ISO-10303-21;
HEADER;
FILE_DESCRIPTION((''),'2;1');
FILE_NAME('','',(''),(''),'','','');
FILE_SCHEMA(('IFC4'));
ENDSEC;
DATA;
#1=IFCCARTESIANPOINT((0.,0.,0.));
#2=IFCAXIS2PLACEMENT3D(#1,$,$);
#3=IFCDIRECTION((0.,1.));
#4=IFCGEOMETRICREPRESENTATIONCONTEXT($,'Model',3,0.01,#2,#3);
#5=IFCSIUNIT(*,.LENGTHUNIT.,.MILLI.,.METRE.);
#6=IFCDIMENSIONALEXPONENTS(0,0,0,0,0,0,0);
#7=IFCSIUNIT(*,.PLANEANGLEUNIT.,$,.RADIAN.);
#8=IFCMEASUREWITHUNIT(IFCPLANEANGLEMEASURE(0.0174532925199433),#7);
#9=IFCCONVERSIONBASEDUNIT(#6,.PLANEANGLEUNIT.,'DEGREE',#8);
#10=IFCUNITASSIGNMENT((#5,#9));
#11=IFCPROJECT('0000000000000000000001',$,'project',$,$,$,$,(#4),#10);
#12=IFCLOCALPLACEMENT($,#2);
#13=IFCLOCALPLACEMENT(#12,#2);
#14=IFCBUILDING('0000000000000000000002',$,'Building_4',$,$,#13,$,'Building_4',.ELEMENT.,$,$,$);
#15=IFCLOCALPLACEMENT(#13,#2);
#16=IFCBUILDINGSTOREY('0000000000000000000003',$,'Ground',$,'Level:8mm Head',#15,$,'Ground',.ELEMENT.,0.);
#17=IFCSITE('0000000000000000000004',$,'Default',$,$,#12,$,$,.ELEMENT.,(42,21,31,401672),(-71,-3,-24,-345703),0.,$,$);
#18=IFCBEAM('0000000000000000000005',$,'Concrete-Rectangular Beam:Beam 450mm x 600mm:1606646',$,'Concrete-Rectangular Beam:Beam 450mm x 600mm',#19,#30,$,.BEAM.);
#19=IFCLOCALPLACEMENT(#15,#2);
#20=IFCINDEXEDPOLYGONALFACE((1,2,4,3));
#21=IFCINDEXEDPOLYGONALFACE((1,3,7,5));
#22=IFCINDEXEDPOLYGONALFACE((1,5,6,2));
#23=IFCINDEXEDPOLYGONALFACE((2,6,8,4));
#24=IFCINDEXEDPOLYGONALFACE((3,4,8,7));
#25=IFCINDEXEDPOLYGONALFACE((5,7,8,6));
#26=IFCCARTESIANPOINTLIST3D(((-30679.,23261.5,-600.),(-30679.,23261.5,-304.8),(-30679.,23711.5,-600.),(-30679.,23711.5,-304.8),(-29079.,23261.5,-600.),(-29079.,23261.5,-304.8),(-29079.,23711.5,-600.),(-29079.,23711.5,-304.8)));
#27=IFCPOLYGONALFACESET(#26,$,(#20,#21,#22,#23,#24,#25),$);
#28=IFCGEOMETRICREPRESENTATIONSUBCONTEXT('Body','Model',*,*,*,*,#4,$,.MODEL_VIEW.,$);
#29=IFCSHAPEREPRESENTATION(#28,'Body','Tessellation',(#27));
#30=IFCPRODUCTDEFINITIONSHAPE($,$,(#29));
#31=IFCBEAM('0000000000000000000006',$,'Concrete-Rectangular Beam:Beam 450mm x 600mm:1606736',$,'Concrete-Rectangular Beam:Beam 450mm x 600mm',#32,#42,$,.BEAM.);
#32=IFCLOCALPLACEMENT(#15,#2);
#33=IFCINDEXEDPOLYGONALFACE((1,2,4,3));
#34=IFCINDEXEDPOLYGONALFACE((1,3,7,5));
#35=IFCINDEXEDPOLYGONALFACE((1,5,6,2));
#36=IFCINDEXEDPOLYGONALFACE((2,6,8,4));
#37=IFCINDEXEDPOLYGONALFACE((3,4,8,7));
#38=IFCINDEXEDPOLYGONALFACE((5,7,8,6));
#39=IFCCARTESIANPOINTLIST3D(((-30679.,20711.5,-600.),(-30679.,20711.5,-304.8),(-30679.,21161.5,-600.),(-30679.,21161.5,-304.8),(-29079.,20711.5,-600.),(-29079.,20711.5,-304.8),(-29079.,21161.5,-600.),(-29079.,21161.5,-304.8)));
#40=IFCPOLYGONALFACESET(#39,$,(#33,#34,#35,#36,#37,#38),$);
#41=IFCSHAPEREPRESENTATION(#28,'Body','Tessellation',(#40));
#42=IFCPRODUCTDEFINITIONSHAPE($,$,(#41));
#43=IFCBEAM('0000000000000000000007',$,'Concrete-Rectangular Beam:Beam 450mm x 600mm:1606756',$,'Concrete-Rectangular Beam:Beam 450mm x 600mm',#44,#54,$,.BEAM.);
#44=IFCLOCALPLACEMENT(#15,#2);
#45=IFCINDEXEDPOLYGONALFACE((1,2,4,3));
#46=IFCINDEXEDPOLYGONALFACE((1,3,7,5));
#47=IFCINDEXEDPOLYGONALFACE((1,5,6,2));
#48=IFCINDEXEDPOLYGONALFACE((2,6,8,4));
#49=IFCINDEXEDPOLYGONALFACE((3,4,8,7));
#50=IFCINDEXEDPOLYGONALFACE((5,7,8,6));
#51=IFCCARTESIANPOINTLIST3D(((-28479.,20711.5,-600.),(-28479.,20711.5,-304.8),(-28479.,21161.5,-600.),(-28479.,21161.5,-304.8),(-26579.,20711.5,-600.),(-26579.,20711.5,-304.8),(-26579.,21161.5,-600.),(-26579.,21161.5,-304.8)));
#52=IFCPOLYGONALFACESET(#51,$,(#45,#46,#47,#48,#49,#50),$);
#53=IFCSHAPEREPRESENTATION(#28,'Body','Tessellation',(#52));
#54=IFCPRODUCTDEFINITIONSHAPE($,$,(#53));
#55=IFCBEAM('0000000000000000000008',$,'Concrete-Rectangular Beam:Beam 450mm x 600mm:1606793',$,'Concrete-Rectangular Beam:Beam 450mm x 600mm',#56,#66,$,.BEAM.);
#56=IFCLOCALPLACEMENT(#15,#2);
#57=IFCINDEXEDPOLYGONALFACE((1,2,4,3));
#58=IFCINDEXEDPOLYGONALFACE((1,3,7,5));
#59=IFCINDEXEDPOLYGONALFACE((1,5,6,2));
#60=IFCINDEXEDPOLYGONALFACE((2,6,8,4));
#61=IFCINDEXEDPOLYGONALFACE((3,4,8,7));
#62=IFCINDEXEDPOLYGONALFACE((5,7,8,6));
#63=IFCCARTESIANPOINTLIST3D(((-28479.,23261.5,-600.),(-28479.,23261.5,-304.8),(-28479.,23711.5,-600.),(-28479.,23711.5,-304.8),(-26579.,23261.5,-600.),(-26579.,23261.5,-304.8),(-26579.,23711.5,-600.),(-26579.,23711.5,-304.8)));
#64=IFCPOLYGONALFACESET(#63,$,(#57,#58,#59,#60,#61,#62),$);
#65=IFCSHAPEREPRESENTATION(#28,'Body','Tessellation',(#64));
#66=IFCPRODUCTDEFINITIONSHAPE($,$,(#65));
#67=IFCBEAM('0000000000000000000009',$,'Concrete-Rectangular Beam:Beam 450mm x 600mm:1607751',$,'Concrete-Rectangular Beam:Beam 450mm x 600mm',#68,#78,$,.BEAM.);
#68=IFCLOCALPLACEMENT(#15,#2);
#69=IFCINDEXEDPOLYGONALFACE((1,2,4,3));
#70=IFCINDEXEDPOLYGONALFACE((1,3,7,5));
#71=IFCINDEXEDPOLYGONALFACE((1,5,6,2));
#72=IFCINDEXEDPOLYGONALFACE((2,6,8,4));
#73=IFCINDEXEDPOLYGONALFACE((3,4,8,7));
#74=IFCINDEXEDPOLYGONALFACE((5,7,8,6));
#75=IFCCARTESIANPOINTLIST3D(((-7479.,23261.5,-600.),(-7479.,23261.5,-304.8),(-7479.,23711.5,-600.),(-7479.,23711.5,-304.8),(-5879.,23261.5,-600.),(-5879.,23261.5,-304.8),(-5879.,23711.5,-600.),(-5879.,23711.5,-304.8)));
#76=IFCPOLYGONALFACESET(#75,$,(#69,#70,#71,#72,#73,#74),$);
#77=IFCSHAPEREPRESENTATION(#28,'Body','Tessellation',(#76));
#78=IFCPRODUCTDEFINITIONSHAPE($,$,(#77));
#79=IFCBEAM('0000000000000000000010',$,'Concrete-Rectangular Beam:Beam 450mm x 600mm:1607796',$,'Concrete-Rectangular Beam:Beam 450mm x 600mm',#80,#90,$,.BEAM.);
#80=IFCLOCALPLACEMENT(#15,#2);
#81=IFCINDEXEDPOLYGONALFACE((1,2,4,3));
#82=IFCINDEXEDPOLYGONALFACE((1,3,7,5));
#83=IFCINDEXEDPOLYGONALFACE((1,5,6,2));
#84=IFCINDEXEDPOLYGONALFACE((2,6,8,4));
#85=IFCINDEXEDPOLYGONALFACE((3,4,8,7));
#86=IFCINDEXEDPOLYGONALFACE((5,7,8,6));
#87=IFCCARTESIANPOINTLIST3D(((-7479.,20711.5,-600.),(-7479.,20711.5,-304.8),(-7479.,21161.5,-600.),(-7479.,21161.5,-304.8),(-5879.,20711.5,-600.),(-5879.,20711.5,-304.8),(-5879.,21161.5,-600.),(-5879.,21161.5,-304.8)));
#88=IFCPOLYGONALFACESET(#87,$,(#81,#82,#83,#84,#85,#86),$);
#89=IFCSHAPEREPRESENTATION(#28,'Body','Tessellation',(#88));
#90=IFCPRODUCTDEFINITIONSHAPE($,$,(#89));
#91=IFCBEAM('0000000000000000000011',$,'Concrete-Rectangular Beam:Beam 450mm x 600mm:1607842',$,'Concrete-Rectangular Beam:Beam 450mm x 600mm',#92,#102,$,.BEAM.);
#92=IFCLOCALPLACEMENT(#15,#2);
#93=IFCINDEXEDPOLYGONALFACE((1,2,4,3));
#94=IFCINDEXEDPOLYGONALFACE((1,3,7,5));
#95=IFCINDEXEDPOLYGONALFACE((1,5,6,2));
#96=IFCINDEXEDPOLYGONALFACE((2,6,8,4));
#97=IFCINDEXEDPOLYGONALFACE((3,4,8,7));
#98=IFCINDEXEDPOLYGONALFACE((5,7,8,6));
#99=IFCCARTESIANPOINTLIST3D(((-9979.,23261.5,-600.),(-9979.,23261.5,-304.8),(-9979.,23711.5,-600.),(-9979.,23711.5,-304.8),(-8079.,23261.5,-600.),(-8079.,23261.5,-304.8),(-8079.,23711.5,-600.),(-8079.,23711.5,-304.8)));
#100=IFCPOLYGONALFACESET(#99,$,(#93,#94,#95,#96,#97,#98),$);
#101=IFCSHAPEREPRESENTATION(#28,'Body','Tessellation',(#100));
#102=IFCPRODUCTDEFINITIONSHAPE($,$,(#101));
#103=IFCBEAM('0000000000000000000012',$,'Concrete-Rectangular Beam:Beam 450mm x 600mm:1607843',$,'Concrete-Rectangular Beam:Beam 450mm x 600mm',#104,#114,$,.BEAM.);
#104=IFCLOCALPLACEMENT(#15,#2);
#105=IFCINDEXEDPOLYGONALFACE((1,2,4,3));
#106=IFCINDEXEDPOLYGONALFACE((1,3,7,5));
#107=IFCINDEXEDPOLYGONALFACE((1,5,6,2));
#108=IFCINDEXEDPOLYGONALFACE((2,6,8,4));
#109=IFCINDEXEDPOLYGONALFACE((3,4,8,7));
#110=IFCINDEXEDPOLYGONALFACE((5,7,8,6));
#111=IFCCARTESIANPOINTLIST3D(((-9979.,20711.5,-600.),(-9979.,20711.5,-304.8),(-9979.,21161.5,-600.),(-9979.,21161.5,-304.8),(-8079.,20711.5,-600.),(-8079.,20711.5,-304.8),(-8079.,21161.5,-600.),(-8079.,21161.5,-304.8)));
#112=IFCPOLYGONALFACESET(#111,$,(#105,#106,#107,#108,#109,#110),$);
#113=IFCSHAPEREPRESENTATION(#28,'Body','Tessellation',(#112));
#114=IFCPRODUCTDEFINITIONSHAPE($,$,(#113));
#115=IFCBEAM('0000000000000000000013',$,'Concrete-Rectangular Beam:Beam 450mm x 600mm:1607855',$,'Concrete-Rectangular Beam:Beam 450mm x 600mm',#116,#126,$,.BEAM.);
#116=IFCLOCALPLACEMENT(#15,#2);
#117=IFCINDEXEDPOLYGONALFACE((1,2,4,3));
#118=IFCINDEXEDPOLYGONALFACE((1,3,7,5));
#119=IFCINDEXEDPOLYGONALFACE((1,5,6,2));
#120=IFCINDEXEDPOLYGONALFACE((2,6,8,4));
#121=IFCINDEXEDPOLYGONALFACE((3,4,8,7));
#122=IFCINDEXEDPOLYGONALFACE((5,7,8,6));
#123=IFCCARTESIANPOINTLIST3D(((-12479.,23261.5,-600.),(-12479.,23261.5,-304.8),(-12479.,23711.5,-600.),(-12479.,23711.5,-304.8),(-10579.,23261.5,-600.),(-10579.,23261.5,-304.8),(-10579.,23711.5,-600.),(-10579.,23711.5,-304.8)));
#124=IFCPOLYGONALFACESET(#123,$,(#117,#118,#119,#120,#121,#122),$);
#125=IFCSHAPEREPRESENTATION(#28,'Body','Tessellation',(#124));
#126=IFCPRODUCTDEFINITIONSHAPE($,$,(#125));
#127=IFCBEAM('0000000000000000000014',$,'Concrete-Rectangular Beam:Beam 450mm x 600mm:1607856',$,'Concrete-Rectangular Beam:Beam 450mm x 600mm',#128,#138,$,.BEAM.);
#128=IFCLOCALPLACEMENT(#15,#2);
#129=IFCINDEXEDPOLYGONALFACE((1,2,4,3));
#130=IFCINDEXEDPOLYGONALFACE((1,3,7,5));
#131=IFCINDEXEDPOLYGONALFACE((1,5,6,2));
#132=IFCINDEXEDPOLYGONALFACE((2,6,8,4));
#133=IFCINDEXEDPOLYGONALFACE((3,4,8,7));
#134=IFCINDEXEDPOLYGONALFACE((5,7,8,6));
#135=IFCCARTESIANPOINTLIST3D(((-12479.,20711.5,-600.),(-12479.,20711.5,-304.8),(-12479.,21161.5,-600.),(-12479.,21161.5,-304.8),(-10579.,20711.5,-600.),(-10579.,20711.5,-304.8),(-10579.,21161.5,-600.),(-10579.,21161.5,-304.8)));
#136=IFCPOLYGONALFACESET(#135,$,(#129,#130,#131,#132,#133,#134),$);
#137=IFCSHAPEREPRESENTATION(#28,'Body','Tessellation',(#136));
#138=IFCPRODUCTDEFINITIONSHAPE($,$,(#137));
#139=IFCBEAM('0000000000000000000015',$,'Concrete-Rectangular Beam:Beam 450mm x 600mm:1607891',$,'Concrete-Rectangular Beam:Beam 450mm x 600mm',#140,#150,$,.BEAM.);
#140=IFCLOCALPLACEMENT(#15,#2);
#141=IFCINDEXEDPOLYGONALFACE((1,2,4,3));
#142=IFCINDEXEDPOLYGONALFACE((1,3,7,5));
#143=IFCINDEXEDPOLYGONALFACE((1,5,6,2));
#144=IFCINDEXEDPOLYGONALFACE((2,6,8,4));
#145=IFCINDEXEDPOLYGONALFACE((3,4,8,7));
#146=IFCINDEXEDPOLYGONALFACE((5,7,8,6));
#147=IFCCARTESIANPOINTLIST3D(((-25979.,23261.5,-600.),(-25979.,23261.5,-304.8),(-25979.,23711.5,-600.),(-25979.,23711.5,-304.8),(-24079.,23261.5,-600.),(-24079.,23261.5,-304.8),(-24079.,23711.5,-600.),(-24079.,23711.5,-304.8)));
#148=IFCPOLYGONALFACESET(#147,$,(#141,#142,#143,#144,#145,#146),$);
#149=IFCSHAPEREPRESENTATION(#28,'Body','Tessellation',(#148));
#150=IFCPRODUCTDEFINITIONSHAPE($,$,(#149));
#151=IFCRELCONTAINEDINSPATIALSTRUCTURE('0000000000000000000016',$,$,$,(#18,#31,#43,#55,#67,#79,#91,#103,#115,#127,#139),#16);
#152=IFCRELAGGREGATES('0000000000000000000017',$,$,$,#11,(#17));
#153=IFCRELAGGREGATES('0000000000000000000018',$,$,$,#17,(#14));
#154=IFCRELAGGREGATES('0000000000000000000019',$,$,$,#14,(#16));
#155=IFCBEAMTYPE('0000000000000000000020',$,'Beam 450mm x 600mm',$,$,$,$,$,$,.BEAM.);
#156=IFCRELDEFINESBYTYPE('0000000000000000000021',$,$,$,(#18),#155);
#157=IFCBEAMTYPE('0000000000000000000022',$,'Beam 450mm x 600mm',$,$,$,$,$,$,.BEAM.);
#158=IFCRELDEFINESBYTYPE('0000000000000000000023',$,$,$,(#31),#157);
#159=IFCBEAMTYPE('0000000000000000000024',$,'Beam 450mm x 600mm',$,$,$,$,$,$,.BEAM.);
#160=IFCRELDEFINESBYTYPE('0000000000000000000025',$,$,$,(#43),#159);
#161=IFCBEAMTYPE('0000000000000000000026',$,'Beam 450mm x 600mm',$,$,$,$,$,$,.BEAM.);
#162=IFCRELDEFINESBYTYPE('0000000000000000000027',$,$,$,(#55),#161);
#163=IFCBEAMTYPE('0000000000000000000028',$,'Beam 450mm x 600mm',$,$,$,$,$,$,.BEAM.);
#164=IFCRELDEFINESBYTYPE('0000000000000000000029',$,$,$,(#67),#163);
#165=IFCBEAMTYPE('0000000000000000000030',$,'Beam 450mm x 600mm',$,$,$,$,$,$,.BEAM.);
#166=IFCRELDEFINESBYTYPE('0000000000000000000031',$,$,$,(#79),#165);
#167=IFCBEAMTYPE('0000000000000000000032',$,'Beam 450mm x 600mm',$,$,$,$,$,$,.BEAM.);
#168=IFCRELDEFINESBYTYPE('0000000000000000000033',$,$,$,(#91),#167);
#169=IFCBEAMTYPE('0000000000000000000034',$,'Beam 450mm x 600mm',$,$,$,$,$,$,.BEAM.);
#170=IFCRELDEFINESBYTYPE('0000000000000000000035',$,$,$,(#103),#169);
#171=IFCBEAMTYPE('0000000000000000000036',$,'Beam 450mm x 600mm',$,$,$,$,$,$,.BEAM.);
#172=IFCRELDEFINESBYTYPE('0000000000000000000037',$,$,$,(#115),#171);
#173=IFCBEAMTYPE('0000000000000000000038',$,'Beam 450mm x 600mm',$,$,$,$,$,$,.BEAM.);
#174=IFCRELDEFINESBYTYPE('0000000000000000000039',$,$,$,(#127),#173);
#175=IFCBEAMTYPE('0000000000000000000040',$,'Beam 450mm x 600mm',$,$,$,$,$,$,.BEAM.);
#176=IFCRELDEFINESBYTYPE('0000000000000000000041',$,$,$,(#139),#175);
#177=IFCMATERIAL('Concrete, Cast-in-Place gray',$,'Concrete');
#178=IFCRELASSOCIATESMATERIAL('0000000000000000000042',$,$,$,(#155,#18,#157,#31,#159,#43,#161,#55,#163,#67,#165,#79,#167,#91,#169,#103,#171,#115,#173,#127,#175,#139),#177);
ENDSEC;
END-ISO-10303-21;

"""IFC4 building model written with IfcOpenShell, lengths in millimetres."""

from ifc_helpers import new_model, entity, si_unit, converted_unit, direction, frame, origin, place, context, subcontext, project, spatial, indexed_curve, outline, extrude, source, transform, mapped, material, type_object, type_shapes, element, save


model = new_model("IFC4")

# Units and contexts
model_context = context("Model", 3, precision=0.01, world=origin(), true_north=direction((0.0, 1.0)))
body_context = subcontext(model_context, "Body", "Model", "MODEL_VIEW")
ifc_project = project(units=[si_unit("LENGTHUNIT", "METRE", prefix="MILLI"), converted_unit("PLANEANGLEUNIT", "DEGREE", entity("IfcPlaneAngleMeasure", 0.0174532925199433), si_unit("PLANEANGLEUNIT", "RADIAN"), dimensions=[0, 0, 0, 0, 0, 0, 0])], contexts=[model_context])

# Site, building, storey
site_placement = place(None, origin())
site = spatial("IfcSite", under=ifc_project, at=site_placement, Name="Default", CompositionType="ELEMENT", RefLatitude=(42, 21, 31, 401672), RefLongitude=(-71, -3, -24, -345703), RefElevation=0.0)
building_placement = place(site_placement, origin())
building = spatial("IfcBuilding", under=site, at=building_placement, Name="Building_4", LongName="Building_4", CompositionType="ELEMENT")
storey_placement = place(building_placement, origin())
storey = spatial("IfcBuildingStorey", under=building, at=storey_placement, Name="Ground", ObjectType="Level:8mm Head", LongName="Ground", CompositionType="ELEMENT", Elevation=0.0)

# Shared definitions
ifc_material_1 = material(Name="Concrete, Cast-in-Place gray", Category="Concrete")

# Beams
beam_type_1 = type_object("IfcBeamType", Name="Beam 450mm x 600mm", PredefinedType="BEAM", material=ifc_material_1)
shared_shape_1 = source(origin(), body_context, "Body", "SweptSolid", [
    extrude(outline(indexed_curve([(-147.6, -225.0), (147.6, -225.0), (147.6, 225.0), (-147.6, 225.0), (-147.6, -225.0)], self_intersect=False)), frame((-30679.0, 23486.5, -452.4), z_axis=(1.0, 0.0, 0.0), x_axis=(0.0, 0.0, -1.0)), (0.0, 0.0, 1.0), 1600.0),
])
type_shapes(beam_type_1, [shared_shape_1])
beam_1_placement = place(storey_placement, origin())
element("IfcBeam", 1, at=beam_1_placement, inside=storey, type_object=beam_type_1, material=ifc_material_1, Name="Concrete-Rectangular Beam:Beam 450mm x 600mm:1606646", ObjectType="Concrete-Rectangular Beam:Beam 450mm x 600mm", PredefinedType="BEAM", context=body_context, shape_type="MappedRepresentation", body=[
    mapped(shared_shape_1, transform((0.0, 0.0, 0.0), scale=1.0)),
])
beam_type_2 = type_object("IfcBeamType", Name="Beam 450mm x 600mm", PredefinedType="BEAM", material=ifc_material_1)
shared_shape_2 = source(origin(), body_context, "Body", "SweptSolid", [
    extrude(outline(indexed_curve([(-147.6, -225.0), (147.6, -225.0), (147.6, 225.0), (-147.6, 225.0), (-147.6, -225.0)], self_intersect=False)), frame((-30679.0, 20936.5, -452.4), z_axis=(1.0, 0.0, 0.0), x_axis=(0.0, 0.0, -1.0)), (0.0, 0.0, 1.0), 1600.0),
])
type_shapes(beam_type_2, [shared_shape_2])
beam_2_placement = place(storey_placement, origin())
element("IfcBeam", 2, at=beam_2_placement, inside=storey, type_object=beam_type_2, material=ifc_material_1, Name="Concrete-Rectangular Beam:Beam 450mm x 600mm:1606736", ObjectType="Concrete-Rectangular Beam:Beam 450mm x 600mm", PredefinedType="BEAM", context=body_context, shape_type="MappedRepresentation", body=[
    mapped(shared_shape_2, transform((0.0, 0.0, 0.0), scale=1.0)),
])
beam_type_3 = type_object("IfcBeamType", Name="Beam 450mm x 600mm", PredefinedType="BEAM", material=ifc_material_1)
shared_shape_3 = source(origin(), body_context, "Body", "SweptSolid", [
    extrude(outline(indexed_curve([(-147.6, -225.0), (147.6, -225.0), (147.6, 225.0), (-147.6, 225.0), (-147.6, -225.0)], self_intersect=False)), frame((-28479.0, 20936.5, -452.4), z_axis=(1.0, 0.0, 0.0), x_axis=(0.0, 0.0, -1.0)), (0.0, 0.0, 1.0), 1900.0),
])
type_shapes(beam_type_3, [shared_shape_3])
beam_3_placement = place(storey_placement, origin())
element("IfcBeam", 3, at=beam_3_placement, inside=storey, type_object=beam_type_3, material=ifc_material_1, Name="Concrete-Rectangular Beam:Beam 450mm x 600mm:1606756", ObjectType="Concrete-Rectangular Beam:Beam 450mm x 600mm", PredefinedType="BEAM", context=body_context, shape_type="MappedRepresentation", body=[
    mapped(shared_shape_3, transform((0.0, 0.0, 0.0), scale=1.0)),
])
beam_type_4 = type_object("IfcBeamType", Name="Beam 450mm x 600mm", PredefinedType="BEAM", material=ifc_material_1)
shared_shape_4 = source(origin(), body_context, "Body", "SweptSolid", [
    extrude(outline(indexed_curve([(-147.6, -225.0), (147.6, -225.0), (147.6, 225.0), (-147.6, 225.0), (-147.6, -225.0)], self_intersect=False)), frame((-26579.0, 23486.5, -452.4), z_axis=(-1.0, 0.0, 0.0), x_axis=(0.0, 0.0, -1.0)), (0.0, 0.0, 1.0), 1900.0),
])
type_shapes(beam_type_4, [shared_shape_4])
beam_4_placement = place(storey_placement, origin())
element("IfcBeam", 4, at=beam_4_placement, inside=storey, type_object=beam_type_4, material=ifc_material_1, Name="Concrete-Rectangular Beam:Beam 450mm x 600mm:1606793", ObjectType="Concrete-Rectangular Beam:Beam 450mm x 600mm", PredefinedType="BEAM", context=body_context, shape_type="MappedRepresentation", body=[
    mapped(shared_shape_4, transform((0.0, 0.0, 0.0), scale=1.0)),
])
beam_type_5 = type_object("IfcBeamType", Name="Beam 450mm x 600mm", PredefinedType="BEAM", material=ifc_material_1)
shared_shape_5 = source(origin(), body_context, "Body", "SweptSolid", [
    extrude(outline(indexed_curve([(-147.6, -225.0), (147.6, -225.0), (147.6, 225.0), (-147.6, 225.0), (-147.6, -225.0)], self_intersect=False)), frame((-7479.0, 23486.5, -452.4), z_axis=(1.0, 0.0, 0.0), x_axis=(0.0, 0.0, -1.0)), (0.0, 0.0, 1.0), 1600.0),
])
type_shapes(beam_type_5, [shared_shape_5])
beam_5_placement = place(storey_placement, origin())
element("IfcBeam", 5, at=beam_5_placement, inside=storey, type_object=beam_type_5, material=ifc_material_1, Name="Concrete-Rectangular Beam:Beam 450mm x 600mm:1607751", ObjectType="Concrete-Rectangular Beam:Beam 450mm x 600mm", PredefinedType="BEAM", context=body_context, shape_type="MappedRepresentation", body=[
    mapped(shared_shape_5, transform((0.0, 0.0, 0.0), scale=1.0)),
])
beam_type_6 = type_object("IfcBeamType", Name="Beam 450mm x 600mm", PredefinedType="BEAM", material=ifc_material_1)
shared_shape_6 = source(origin(), body_context, "Body", "SweptSolid", [
    extrude(outline(indexed_curve([(-147.6, -225.0), (147.6, -225.0), (147.6, 225.0), (-147.6, 225.0), (-147.6, -225.0)], self_intersect=False)), frame((-7479.0, 20936.5, -452.4), z_axis=(1.0, 0.0, 0.0), x_axis=(0.0, 0.0, -1.0)), (0.0, 0.0, 1.0), 1600.0),
])
type_shapes(beam_type_6, [shared_shape_6])
beam_6_placement = place(storey_placement, origin())
element("IfcBeam", 6, at=beam_6_placement, inside=storey, type_object=beam_type_6, material=ifc_material_1, Name="Concrete-Rectangular Beam:Beam 450mm x 600mm:1607796", ObjectType="Concrete-Rectangular Beam:Beam 450mm x 600mm", PredefinedType="BEAM", context=body_context, shape_type="MappedRepresentation", body=[
    mapped(shared_shape_6, transform((0.0, 0.0, 0.0), scale=1.0)),
])
beam_type_7 = type_object("IfcBeamType", Name="Beam 450mm x 600mm", PredefinedType="BEAM", material=ifc_material_1)
shared_shape_7 = source(origin(), body_context, "Body", "SweptSolid", [
    extrude(outline(indexed_curve([(-147.6, -225.0), (147.6, -225.0), (147.6, 225.0), (-147.6, 225.0), (-147.6, -225.0)], self_intersect=False)), frame((-9979.0, 23486.5, -452.4), z_axis=(1.0, 0.0, 0.0), x_axis=(0.0, 0.0, -1.0)), (0.0, 0.0, 1.0), 1900.0),
])
type_shapes(beam_type_7, [shared_shape_7])
beam_7_placement = place(storey_placement, origin())
element("IfcBeam", 7, at=beam_7_placement, inside=storey, type_object=beam_type_7, material=ifc_material_1, Name="Concrete-Rectangular Beam:Beam 450mm x 600mm:1607842", ObjectType="Concrete-Rectangular Beam:Beam 450mm x 600mm", PredefinedType="BEAM", context=body_context, shape_type="MappedRepresentation", body=[
    mapped(shared_shape_7, transform((0.0, 0.0, 0.0), scale=1.0)),
])
beam_type_8 = type_object("IfcBeamType", Name="Beam 450mm x 600mm", PredefinedType="BEAM", material=ifc_material_1)
shared_shape_8 = source(origin(), body_context, "Body", "SweptSolid", [
    extrude(outline(indexed_curve([(-147.6, -225.0), (147.6, -225.0), (147.6, 225.0), (-147.6, 225.0), (-147.6, -225.0)], self_intersect=False)), frame((-9979.0, 20936.5, -452.4), z_axis=(1.0, 0.0, 0.0), x_axis=(0.0, 0.0, -1.0)), (0.0, 0.0, 1.0), 1900.0),
])
type_shapes(beam_type_8, [shared_shape_8])
beam_8_placement = place(storey_placement, origin())
element("IfcBeam", 8, at=beam_8_placement, inside=storey, type_object=beam_type_8, material=ifc_material_1, Name="Concrete-Rectangular Beam:Beam 450mm x 600mm:1607843", ObjectType="Concrete-Rectangular Beam:Beam 450mm x 600mm", PredefinedType="BEAM", context=body_context, shape_type="MappedRepresentation", body=[
    mapped(shared_shape_8, transform((0.0, 0.0, 0.0), scale=1.0)),
])
beam_type_9 = type_object("IfcBeamType", Name="Beam 450mm x 600mm", PredefinedType="BEAM", material=ifc_material_1)
shared_shape_9 = source(origin(), body_context, "Body", "SweptSolid", [
    extrude(outline(indexed_curve([(-147.6, -225.0), (147.6, -225.0), (147.6, 225.0), (-147.6, 225.0), (-147.6, -225.0)], self_intersect=False)), frame((-12479.0, 23486.5, -452.4), z_axis=(1.0, 0.0, 0.0), x_axis=(0.0, 0.0, -1.0)), (0.0, 0.0, 1.0), 1900.0),
])
type_shapes(beam_type_9, [shared_shape_9])
beam_9_placement = place(storey_placement, origin())
element("IfcBeam", 9, at=beam_9_placement, inside=storey, type_object=beam_type_9, material=ifc_material_1, Name="Concrete-Rectangular Beam:Beam 450mm x 600mm:1607855", ObjectType="Concrete-Rectangular Beam:Beam 450mm x 600mm", PredefinedType="BEAM", context=body_context, shape_type="MappedRepresentation", body=[
    mapped(shared_shape_9, transform((0.0, 0.0, 0.0), scale=1.0)),
])
beam_type_10 = type_object("IfcBeamType", Name="Beam 450mm x 600mm", PredefinedType="BEAM", material=ifc_material_1)
shared_shape_10 = source(origin(), body_context, "Body", "SweptSolid", [
    extrude(outline(indexed_curve([(-147.6, -225.0), (147.6, -225.0), (147.6, 225.0), (-147.6, 225.0), (-147.6, -225.0)], self_intersect=False)), frame((-12479.0, 20936.5, -452.4), z_axis=(1.0, 0.0, 0.0), x_axis=(0.0, 0.0, -1.0)), (0.0, 0.0, 1.0), 1900.0),
])
type_shapes(beam_type_10, [shared_shape_10])
beam_10_placement = place(storey_placement, origin())
element("IfcBeam", 10, at=beam_10_placement, inside=storey, type_object=beam_type_10, material=ifc_material_1, Name="Concrete-Rectangular Beam:Beam 450mm x 600mm:1607856", ObjectType="Concrete-Rectangular Beam:Beam 450mm x 600mm", PredefinedType="BEAM", context=body_context, shape_type="MappedRepresentation", body=[
    mapped(shared_shape_10, transform((0.0, 0.0, 0.0), scale=1.0)),
])
beam_type_11 = type_object("IfcBeamType", Name="Beam 450mm x 600mm", PredefinedType="BEAM", material=ifc_material_1)
shared_shape_11 = source(origin(), body_context, "Body", "SweptSolid", [
    extrude(outline(indexed_curve([(-147.6, -225.0), (147.6, -225.0), (147.6, 225.0), (-147.6, 225.0), (-147.6, -225.0)], self_intersect=False)), frame((-25979.0, 23486.5, -452.4), z_axis=(1.0, 0.0, 0.0), x_axis=(0.0, 0.0, -1.0)), (0.0, 0.0, 1.0), 1900.0),
])
type_shapes(beam_type_11, [shared_shape_11])
beam_11_placement = place(storey_placement, origin())
element("IfcBeam", 11, at=beam_11_placement, inside=storey, type_object=beam_type_11, material=ifc_material_1, Name="Concrete-Rectangular Beam:Beam 450mm x 600mm:1607891", ObjectType="Concrete-Rectangular Beam:Beam 450mm x 600mm", PredefinedType="BEAM", context=body_context, shape_type="MappedRepresentation", body=[
    mapped(shared_shape_11, transform((0.0, 0.0, 0.0), scale=1.0)),
])

save(model, "model.ifc")
